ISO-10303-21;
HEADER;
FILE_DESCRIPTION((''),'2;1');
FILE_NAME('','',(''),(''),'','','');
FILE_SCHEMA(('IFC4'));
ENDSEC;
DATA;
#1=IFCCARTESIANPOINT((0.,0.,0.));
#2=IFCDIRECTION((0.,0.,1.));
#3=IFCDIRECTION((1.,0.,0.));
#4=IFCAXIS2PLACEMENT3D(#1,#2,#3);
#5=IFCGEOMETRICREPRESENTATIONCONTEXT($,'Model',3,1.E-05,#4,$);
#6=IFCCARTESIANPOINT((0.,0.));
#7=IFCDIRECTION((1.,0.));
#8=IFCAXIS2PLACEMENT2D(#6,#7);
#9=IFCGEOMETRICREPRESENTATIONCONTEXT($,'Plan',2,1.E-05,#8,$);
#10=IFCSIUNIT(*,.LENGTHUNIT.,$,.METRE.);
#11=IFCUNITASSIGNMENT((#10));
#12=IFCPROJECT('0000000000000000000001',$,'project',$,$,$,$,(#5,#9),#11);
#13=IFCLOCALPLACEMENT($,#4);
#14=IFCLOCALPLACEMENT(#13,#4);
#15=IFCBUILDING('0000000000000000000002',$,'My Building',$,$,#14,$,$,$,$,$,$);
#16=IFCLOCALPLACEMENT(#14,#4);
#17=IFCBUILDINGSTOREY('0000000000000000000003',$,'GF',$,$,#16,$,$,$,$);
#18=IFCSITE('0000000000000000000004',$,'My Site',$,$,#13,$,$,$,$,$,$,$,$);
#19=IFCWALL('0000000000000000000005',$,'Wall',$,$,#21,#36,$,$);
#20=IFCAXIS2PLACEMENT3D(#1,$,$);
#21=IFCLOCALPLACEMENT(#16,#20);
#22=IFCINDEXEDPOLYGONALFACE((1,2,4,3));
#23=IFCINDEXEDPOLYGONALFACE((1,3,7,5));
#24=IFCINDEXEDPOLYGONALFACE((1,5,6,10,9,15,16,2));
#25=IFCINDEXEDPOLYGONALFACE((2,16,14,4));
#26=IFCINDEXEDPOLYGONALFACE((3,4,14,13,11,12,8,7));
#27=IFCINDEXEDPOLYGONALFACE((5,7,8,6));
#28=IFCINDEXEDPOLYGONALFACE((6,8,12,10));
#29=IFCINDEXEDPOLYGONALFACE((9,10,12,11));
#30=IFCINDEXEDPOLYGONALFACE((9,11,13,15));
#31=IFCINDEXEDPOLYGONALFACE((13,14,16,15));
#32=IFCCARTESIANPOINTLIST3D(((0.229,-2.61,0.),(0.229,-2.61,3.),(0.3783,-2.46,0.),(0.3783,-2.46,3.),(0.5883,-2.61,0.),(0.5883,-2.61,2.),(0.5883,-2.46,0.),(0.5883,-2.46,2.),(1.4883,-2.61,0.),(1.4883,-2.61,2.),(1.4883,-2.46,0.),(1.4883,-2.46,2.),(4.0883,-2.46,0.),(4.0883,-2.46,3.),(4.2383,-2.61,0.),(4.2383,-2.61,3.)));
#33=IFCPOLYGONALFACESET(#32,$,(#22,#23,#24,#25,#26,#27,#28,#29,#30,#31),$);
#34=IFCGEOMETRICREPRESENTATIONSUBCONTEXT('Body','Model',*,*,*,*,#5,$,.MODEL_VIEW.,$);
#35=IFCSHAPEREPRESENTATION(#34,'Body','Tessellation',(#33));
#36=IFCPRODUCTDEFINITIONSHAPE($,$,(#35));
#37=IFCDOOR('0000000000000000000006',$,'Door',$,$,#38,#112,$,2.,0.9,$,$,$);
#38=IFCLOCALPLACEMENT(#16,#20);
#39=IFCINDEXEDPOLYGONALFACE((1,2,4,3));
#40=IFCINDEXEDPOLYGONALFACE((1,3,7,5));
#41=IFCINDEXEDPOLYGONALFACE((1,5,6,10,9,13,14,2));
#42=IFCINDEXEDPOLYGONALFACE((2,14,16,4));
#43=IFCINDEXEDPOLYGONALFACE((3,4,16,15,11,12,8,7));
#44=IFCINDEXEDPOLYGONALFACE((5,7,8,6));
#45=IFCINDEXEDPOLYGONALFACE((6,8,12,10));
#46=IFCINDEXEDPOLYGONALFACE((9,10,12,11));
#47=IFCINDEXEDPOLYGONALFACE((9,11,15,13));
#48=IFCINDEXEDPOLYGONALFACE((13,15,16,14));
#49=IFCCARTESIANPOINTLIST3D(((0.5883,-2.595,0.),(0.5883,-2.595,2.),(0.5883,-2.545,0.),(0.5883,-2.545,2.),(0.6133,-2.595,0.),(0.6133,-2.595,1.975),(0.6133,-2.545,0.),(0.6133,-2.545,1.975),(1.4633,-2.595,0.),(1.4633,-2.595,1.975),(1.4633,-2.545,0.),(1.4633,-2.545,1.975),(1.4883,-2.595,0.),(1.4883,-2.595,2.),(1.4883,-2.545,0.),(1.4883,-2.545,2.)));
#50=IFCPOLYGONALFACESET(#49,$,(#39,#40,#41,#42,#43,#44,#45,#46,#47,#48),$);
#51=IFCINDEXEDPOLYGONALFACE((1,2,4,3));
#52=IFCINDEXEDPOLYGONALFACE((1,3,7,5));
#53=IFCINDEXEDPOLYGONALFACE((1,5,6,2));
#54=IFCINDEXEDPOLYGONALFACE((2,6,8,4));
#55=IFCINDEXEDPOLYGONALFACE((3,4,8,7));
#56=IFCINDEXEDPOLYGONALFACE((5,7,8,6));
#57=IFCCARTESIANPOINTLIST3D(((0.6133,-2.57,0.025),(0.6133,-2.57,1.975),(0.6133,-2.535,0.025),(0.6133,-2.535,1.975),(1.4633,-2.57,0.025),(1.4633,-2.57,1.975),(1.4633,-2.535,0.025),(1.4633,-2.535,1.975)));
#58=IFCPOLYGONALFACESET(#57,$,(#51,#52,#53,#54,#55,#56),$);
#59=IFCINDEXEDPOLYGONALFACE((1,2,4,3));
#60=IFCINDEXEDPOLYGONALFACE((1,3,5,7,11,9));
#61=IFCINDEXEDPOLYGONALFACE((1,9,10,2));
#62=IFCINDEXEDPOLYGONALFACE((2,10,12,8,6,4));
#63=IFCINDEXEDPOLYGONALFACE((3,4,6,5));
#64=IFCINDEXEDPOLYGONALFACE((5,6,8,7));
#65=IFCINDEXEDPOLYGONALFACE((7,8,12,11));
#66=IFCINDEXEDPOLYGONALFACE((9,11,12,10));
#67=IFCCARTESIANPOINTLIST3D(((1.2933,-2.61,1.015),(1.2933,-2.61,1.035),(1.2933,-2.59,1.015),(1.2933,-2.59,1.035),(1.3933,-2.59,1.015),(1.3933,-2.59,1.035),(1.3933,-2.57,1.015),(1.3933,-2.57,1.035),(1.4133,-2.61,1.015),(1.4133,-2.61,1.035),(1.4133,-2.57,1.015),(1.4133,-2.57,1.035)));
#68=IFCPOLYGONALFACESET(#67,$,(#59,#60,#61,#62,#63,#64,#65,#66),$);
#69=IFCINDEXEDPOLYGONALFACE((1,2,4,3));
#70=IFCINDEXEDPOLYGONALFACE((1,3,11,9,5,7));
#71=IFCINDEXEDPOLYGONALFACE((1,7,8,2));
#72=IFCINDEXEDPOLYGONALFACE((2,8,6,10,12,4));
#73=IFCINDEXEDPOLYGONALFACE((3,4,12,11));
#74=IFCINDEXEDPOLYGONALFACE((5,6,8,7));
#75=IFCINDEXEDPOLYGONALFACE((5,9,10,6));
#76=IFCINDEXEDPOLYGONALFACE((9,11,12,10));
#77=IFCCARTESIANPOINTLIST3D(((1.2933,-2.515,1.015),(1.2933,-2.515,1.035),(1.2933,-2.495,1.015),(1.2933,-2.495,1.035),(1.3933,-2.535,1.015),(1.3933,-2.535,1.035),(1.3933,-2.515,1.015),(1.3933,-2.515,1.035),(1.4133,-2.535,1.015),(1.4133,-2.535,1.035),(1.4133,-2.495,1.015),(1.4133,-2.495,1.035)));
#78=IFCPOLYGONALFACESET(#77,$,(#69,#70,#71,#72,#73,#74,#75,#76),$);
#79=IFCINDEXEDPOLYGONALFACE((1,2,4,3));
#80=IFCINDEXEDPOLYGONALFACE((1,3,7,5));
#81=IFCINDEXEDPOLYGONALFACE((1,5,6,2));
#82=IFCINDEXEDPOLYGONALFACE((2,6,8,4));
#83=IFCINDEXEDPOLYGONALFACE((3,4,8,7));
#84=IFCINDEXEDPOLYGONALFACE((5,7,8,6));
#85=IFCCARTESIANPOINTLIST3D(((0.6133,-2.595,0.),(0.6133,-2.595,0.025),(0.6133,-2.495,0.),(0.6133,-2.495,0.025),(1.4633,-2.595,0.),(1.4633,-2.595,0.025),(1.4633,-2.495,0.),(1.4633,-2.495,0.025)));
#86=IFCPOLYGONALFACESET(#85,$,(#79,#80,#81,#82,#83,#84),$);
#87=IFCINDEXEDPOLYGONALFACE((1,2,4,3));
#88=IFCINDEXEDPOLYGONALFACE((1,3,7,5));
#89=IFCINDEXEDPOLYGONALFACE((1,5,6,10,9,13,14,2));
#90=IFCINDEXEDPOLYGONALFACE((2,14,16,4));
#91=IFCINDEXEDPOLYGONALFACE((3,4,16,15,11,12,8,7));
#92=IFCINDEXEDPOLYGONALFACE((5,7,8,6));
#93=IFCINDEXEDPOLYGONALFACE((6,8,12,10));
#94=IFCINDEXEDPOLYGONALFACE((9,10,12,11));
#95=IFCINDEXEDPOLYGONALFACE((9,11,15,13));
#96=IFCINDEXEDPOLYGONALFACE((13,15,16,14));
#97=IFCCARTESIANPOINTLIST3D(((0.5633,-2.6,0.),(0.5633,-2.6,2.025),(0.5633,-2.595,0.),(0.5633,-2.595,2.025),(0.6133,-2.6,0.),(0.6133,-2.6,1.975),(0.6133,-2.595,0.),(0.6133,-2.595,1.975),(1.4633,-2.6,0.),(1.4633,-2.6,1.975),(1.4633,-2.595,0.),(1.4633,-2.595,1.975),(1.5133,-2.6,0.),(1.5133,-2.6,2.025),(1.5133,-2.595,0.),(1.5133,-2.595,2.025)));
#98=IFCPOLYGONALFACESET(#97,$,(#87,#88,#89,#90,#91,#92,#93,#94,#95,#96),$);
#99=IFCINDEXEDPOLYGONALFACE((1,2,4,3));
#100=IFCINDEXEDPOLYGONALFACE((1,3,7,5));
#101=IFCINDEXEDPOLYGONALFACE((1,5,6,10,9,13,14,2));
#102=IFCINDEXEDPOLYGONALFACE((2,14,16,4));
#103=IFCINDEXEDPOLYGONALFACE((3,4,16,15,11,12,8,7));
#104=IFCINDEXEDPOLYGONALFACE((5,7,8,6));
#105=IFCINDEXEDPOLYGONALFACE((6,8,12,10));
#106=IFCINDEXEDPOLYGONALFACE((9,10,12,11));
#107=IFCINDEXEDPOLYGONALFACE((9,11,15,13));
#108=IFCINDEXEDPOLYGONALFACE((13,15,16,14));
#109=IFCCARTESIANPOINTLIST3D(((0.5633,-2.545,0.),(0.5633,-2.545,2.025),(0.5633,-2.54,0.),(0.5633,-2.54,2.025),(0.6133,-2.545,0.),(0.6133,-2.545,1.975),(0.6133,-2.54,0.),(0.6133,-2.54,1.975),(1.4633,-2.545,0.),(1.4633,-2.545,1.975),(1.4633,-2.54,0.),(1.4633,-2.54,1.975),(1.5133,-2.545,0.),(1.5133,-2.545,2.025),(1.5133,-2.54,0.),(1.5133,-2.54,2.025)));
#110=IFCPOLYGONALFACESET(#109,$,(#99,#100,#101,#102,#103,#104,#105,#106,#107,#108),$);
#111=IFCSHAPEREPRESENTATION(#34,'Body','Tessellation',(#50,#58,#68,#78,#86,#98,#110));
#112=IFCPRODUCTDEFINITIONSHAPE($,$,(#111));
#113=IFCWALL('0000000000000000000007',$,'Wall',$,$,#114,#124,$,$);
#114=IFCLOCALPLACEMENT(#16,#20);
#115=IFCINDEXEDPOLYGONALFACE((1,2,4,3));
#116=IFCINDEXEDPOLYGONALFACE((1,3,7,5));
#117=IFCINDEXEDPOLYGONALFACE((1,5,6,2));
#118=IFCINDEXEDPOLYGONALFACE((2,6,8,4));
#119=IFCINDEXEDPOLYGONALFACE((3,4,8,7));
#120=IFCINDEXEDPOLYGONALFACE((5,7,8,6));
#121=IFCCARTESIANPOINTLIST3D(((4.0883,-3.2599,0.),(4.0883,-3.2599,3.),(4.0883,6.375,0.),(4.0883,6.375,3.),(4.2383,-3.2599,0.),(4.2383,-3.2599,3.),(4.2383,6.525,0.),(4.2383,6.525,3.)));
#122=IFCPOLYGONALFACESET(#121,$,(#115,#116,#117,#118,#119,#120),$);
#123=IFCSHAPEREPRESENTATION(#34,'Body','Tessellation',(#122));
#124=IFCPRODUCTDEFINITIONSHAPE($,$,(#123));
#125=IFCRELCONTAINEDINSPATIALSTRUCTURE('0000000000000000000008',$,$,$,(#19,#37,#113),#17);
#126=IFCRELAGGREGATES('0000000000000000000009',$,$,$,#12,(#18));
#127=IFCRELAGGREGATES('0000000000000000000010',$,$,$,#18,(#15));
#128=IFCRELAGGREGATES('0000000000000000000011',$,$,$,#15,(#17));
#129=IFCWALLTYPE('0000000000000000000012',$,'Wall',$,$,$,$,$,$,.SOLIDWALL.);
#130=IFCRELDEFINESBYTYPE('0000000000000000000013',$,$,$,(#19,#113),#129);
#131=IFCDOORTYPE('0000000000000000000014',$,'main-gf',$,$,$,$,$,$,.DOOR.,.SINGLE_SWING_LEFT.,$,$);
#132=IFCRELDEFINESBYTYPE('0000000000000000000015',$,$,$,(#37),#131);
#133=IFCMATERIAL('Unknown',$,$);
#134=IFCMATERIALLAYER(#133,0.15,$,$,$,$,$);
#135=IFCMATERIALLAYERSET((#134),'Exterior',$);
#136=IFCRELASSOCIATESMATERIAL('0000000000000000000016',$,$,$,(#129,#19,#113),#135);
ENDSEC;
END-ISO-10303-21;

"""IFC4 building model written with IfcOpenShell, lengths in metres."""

from ifc_helpers import new_model, entity, si_unit, frame, origin_with_axes, origin_2d_with_axis, place, context, subcontext, project, spatial, line, indexed_curve, outline, extrude, shape, source, transform, mapped, material, layer, layer_set, layer_usage, type_object, type_shapes, element, fill, save


model = new_model("IFC4")

# Units and contexts
model_context = context("Model", 3, precision=1e-05, world=origin_with_axes())
plan_context = context("Plan", 2, precision=1e-05, world=origin_2d_with_axis())
body_context_1 = subcontext(model_context, "Body", "Model", "MODEL_VIEW")
body_context_2 = subcontext(plan_context, "Body", "Plan", "PLAN_VIEW")
ifc_project = project(units=[si_unit("LENGTHUNIT", "METRE")], contexts=[model_context, plan_context])

# Site, building, storey
site_placement = place(None, origin_with_axes())
site = spatial("IfcSite", under=ifc_project, at=site_placement, Name="My Site")
building_placement = place(site_placement, origin_with_axes())
building = spatial("IfcBuilding", under=site, at=building_placement, Name="My Building")
storey_placement = place(building_placement, origin_with_axes())
storey = spatial("IfcBuildingStorey", under=building, at=storey_placement, Name="GF")

# Shared definitions
ifc_material = material(Name="Unknown")

# Wall, opening, door
ifc_layer_1 = layer(ifc_material, 0.15)
ifc_layer_set_1 = layer_set([ifc_layer_1], Name="Exterior")
ifc_layer_usage_1 = layer_usage(ifc_layer_set_1, "AXIS2", "POSITIVE", 0.0)
wall_type_1 = type_object("IfcWallType", Name="Wall", PredefinedType="SOLIDWALL", material=ifc_layer_set_1)
wall_1_placement = place(storey_placement, frame((0.229, -2.61, 0.0), z_axis=(0.0, 0.0, 1.0), x_axis=(1.0, 0.0, 0.0)))
wall_1 = element("IfcWall", 1, at=wall_1_placement, inside=storey, type_object=wall_type_1, material=ifc_layer_usage_1, Name="Wall", context=body_context_1, shape_type="SweptSolid", body=[
    extrude(outline(indexed_curve([(0.0, 0.0), (0.1494, 0.15), (3.8594, 0.15), (4.0094, 0.0)], segments=[line(1, 2, 3, 4, 1)])), origin_with_axes(), (0.0, 0.0, 1.0), 3.0),
])
shared_shape_1 = source(origin_with_axes(), body_context_1, "Body", "SweptSolid", [
    extrude(outline(indexed_curve([(0.0, 0.0), (0.9, 0.0), (0.9, 2.0), (0.0, 2.0)], segments=[line(1, 2, 3, 4, 1)])), frame((0.0, -0.6, 0.0), z_axis=(0.0, -1.0, 0.0), x_axis=(1.0, 0.0, 0.0)), (0.0, 0.0, -1.0), 1.2),
])
opening_1_placement = place(wall_1_placement, frame((0.3593, 0.015, 0.0), z_axis=(0.0, 0.0, 1.0), x_axis=(1.0, -0.000001, 0.0)))
opening_1 = element("IfcOpeningElement", 2, at=opening_1_placement, cuts=wall_1, PredefinedType="OPENING", context=body_context_1, shape_type="MappedRepresentation", body=[
    mapped(shared_shape_1, transform((0.0, 0.0, 0.0), x_axis=(1.0, 0.0, 0.0), y_axis=(0.0, 1.0, 0.0), z_axis=(0.0, 0.0, 1.0), scale=1.0)),
])
door_type = type_object("IfcDoorType", Name="main-gf", OperationType="SINGLE_SWING_LEFT", PredefinedType="DOOR")
shared_shape_2 = source(origin_with_axes(), body_context_1, "Body", "SweptSolid", [
    extrude(outline(indexed_curve([(0.0, 0.0), (0.0, 2.0), (0.9, 2.0), (0.9, 0.0), (0.875, 0.0), (0.875, 1.975), (0.025, 1.975), (0.025, 0.0)], segments=[line(1, 2, 3, 4, 5, 6, 7, 8, 1)])), frame((0.0, 0.0, 0.0), z_axis=(0.0, -1.0, 0.0), x_axis=(1.0, 0.0, 0.0)), (0.0, 0.0, -1.0), 0.05),
    extrude(outline(indexed_curve([(0.0, 0.0), (0.85, 0.0), (0.85, 0.035), (0.0, 0.035)], segments=[line(1, 2, 3, 4, 1)])), frame((0.025, 0.025, 0.025), z_axis=(0.0, 0.0, 1.0), x_axis=(1.0, 0.0, 0.0)), (0.0, 0.0, 1.0), 1.95),
    extrude(outline(indexed_curve([(0.0, 0.0), (0.0, -0.04), (-0.12, -0.04), (-0.12, -0.02), (-0.02, -0.02), (-0.02, 0.0)], segments=[line(1, 2, 3, 4, 5, 6, 1)])), frame((0.825, 0.025, 1.015), z_axis=(0.0, 0.0, 1.0), x_axis=(1.0, 0.0, 0.0)), (0.0, 0.0, 1.0), 0.02),
    extrude(outline(indexed_curve([(0.0, 0.0), (0.0, 0.04), (-0.12, 0.04), (-0.12, 0.02), (-0.02, 0.02), (-0.02, 0.0)], segments=[line(1, 2, 3, 4, 5, 6, 1)])), frame((0.825, 0.06, 1.015), z_axis=(0.0, 0.0, 1.0), x_axis=(1.0, 0.0, 0.0)), (0.0, 0.0, 1.0), 0.02),
    extrude(outline(indexed_curve([(0.0, 0.0), (0.85, 0.0), (0.85, 0.1), (0.0, 0.1)], segments=[line(1, 2, 3, 4, 1)])), frame((0.025, 0.0, 0.0), z_axis=(0.0, 0.0, 1.0), x_axis=(1.0, 0.0, 0.0)), (0.0, 0.0, 1.0), 0.025),
    extrude(outline(indexed_curve([(0.0, 0.0), (0.0, 2.025), (0.95, 2.025), (0.95, 0.0), (0.9, 0.0), (0.9, 1.975), (0.05, 1.975), (0.05, 0.0)], segments=[line(1, 2, 3, 4, 5, 6, 7, 8, 1)])), frame((-0.025, -0.005, 0.0), z_axis=(0.0, -1.0, 0.0), x_axis=(1.0, 0.0, 0.0)), (0.0, 0.0, -1.0), 0.005),
    extrude(outline(indexed_curve([(0.0, 0.0), (0.0, 2.025), (0.95, 2.025), (0.95, 0.0), (0.9, 0.0), (0.9, 1.975), (0.05, 1.975), (0.05, 0.0)], segments=[line(1, 2, 3, 4, 5, 6, 7, 8, 1)])), frame((-0.025, 0.05, 0.0), z_axis=(0.0, -1.0, 0.0), x_axis=(1.0, 0.0, 0.0)), (0.0, 0.0, -1.0), 0.005),
])
shared_shape_3 = source(origin_with_axes(), body_context_2, "Body", "Curve2D", [
    entity("IfcIndexedPolyCurve", entity("IfcCartesianPointList2D", [[0.0, 0.0], [0.025, 0.0], [0.025, 0.05], [0.0, 0.05]]), [entity("IfcLineIndex", [1, 2, 3, 4, 1])]),
    entity("IfcIndexedPolyCurve", entity("IfcCartesianPointList2D", [[0.9, 0.0], [0.875, 0.0], [0.875, 0.05], [0.9, 0.05]]), [entity("IfcLineIndex", [1, 2, 3, 4, 1])]),
    entity("IfcIndexedPolyCurve", entity("IfcCartesianPointList2D", [[0.025, 0.05], [0.025, -0.8], [0.06, -0.8]])),
    entity("IfcTrimmedCurve", entity("IfcEllipse", entity("IfcAxis2Placement2D", entity("IfcCartesianPoint", [0.06, 0.05]), entity("IfcDirection", [1.0, 0.0])), 0.815, 0.85), [entity("IfcCartesianPoint", [0.06, -0.8])], [entity("IfcCartesianPoint", [0.06, 0.9])], True, "CARTESIAN"),
    entity("IfcIndexedPolyCurve", entity("IfcCartesianPointList2D", [[0.025, 0.05], [0.06, 0.05], [0.06, 0.9], [0.025, 0.9]]), [entity("IfcLineIndex", [1, 2, 3, 4, 1])]),
])
type_shapes(door_type, [shared_shape_2, shared_shape_3])
door_1_placement = place(opening_1_placement, origin_with_axes())
door_1 = element("IfcDoor", 3, at=door_1_placement, inside=storey, type_object=door_type, Name="Door", OverallHeight=2.0, OverallWidth=0.9, shapes=[
    shape(body_context_1, "Body", "MappedRepresentation", [mapped(shared_shape_2, transform((0.0, 0.0, 0.0), x_axis=(1.0, 0.0, 0.0), y_axis=(0.0, 1.0, 0.0), z_axis=(0.0, 0.0, 1.0), scale=1.0))]),
    shape(body_context_2, "Body", "MappedRepresentation", [mapped(shared_shape_3, transform((0.0, 0.0, 0.0), x_axis=(1.0, 0.0, 0.0), y_axis=(0.0, 1.0, 0.0), z_axis=(0.0, 0.0, 1.0), scale=1.0))]),
])
fill(opening_1, door_1)

# Wall
ifc_layer_usage_2 = layer_usage(ifc_layer_set_1, "AXIS2", "POSITIVE", 0.0)
wall_2_placement = place(storey_placement, frame((4.2383, -3.2599, 0.0), z_axis=(0.0, 0.0, 1.0), x_axis=(0.0, 1.0, 0.0)))
element("IfcWall", 4, at=wall_2_placement, inside=storey, type_object=wall_type_1, material=ifc_layer_usage_2, Name="Wall", context=body_context_1, shape_type="SweptSolid", body=[
    extrude(outline(indexed_curve([(0.0, 0.0), (0.0, 0.15), (9.6349, 0.15), (9.7849, 0.0)], segments=[line(1, 2, 3, 4, 1)])), origin_with_axes(), (0.0, 0.0, 1.0), 3.0),
])

save(model, "model.ifc")
